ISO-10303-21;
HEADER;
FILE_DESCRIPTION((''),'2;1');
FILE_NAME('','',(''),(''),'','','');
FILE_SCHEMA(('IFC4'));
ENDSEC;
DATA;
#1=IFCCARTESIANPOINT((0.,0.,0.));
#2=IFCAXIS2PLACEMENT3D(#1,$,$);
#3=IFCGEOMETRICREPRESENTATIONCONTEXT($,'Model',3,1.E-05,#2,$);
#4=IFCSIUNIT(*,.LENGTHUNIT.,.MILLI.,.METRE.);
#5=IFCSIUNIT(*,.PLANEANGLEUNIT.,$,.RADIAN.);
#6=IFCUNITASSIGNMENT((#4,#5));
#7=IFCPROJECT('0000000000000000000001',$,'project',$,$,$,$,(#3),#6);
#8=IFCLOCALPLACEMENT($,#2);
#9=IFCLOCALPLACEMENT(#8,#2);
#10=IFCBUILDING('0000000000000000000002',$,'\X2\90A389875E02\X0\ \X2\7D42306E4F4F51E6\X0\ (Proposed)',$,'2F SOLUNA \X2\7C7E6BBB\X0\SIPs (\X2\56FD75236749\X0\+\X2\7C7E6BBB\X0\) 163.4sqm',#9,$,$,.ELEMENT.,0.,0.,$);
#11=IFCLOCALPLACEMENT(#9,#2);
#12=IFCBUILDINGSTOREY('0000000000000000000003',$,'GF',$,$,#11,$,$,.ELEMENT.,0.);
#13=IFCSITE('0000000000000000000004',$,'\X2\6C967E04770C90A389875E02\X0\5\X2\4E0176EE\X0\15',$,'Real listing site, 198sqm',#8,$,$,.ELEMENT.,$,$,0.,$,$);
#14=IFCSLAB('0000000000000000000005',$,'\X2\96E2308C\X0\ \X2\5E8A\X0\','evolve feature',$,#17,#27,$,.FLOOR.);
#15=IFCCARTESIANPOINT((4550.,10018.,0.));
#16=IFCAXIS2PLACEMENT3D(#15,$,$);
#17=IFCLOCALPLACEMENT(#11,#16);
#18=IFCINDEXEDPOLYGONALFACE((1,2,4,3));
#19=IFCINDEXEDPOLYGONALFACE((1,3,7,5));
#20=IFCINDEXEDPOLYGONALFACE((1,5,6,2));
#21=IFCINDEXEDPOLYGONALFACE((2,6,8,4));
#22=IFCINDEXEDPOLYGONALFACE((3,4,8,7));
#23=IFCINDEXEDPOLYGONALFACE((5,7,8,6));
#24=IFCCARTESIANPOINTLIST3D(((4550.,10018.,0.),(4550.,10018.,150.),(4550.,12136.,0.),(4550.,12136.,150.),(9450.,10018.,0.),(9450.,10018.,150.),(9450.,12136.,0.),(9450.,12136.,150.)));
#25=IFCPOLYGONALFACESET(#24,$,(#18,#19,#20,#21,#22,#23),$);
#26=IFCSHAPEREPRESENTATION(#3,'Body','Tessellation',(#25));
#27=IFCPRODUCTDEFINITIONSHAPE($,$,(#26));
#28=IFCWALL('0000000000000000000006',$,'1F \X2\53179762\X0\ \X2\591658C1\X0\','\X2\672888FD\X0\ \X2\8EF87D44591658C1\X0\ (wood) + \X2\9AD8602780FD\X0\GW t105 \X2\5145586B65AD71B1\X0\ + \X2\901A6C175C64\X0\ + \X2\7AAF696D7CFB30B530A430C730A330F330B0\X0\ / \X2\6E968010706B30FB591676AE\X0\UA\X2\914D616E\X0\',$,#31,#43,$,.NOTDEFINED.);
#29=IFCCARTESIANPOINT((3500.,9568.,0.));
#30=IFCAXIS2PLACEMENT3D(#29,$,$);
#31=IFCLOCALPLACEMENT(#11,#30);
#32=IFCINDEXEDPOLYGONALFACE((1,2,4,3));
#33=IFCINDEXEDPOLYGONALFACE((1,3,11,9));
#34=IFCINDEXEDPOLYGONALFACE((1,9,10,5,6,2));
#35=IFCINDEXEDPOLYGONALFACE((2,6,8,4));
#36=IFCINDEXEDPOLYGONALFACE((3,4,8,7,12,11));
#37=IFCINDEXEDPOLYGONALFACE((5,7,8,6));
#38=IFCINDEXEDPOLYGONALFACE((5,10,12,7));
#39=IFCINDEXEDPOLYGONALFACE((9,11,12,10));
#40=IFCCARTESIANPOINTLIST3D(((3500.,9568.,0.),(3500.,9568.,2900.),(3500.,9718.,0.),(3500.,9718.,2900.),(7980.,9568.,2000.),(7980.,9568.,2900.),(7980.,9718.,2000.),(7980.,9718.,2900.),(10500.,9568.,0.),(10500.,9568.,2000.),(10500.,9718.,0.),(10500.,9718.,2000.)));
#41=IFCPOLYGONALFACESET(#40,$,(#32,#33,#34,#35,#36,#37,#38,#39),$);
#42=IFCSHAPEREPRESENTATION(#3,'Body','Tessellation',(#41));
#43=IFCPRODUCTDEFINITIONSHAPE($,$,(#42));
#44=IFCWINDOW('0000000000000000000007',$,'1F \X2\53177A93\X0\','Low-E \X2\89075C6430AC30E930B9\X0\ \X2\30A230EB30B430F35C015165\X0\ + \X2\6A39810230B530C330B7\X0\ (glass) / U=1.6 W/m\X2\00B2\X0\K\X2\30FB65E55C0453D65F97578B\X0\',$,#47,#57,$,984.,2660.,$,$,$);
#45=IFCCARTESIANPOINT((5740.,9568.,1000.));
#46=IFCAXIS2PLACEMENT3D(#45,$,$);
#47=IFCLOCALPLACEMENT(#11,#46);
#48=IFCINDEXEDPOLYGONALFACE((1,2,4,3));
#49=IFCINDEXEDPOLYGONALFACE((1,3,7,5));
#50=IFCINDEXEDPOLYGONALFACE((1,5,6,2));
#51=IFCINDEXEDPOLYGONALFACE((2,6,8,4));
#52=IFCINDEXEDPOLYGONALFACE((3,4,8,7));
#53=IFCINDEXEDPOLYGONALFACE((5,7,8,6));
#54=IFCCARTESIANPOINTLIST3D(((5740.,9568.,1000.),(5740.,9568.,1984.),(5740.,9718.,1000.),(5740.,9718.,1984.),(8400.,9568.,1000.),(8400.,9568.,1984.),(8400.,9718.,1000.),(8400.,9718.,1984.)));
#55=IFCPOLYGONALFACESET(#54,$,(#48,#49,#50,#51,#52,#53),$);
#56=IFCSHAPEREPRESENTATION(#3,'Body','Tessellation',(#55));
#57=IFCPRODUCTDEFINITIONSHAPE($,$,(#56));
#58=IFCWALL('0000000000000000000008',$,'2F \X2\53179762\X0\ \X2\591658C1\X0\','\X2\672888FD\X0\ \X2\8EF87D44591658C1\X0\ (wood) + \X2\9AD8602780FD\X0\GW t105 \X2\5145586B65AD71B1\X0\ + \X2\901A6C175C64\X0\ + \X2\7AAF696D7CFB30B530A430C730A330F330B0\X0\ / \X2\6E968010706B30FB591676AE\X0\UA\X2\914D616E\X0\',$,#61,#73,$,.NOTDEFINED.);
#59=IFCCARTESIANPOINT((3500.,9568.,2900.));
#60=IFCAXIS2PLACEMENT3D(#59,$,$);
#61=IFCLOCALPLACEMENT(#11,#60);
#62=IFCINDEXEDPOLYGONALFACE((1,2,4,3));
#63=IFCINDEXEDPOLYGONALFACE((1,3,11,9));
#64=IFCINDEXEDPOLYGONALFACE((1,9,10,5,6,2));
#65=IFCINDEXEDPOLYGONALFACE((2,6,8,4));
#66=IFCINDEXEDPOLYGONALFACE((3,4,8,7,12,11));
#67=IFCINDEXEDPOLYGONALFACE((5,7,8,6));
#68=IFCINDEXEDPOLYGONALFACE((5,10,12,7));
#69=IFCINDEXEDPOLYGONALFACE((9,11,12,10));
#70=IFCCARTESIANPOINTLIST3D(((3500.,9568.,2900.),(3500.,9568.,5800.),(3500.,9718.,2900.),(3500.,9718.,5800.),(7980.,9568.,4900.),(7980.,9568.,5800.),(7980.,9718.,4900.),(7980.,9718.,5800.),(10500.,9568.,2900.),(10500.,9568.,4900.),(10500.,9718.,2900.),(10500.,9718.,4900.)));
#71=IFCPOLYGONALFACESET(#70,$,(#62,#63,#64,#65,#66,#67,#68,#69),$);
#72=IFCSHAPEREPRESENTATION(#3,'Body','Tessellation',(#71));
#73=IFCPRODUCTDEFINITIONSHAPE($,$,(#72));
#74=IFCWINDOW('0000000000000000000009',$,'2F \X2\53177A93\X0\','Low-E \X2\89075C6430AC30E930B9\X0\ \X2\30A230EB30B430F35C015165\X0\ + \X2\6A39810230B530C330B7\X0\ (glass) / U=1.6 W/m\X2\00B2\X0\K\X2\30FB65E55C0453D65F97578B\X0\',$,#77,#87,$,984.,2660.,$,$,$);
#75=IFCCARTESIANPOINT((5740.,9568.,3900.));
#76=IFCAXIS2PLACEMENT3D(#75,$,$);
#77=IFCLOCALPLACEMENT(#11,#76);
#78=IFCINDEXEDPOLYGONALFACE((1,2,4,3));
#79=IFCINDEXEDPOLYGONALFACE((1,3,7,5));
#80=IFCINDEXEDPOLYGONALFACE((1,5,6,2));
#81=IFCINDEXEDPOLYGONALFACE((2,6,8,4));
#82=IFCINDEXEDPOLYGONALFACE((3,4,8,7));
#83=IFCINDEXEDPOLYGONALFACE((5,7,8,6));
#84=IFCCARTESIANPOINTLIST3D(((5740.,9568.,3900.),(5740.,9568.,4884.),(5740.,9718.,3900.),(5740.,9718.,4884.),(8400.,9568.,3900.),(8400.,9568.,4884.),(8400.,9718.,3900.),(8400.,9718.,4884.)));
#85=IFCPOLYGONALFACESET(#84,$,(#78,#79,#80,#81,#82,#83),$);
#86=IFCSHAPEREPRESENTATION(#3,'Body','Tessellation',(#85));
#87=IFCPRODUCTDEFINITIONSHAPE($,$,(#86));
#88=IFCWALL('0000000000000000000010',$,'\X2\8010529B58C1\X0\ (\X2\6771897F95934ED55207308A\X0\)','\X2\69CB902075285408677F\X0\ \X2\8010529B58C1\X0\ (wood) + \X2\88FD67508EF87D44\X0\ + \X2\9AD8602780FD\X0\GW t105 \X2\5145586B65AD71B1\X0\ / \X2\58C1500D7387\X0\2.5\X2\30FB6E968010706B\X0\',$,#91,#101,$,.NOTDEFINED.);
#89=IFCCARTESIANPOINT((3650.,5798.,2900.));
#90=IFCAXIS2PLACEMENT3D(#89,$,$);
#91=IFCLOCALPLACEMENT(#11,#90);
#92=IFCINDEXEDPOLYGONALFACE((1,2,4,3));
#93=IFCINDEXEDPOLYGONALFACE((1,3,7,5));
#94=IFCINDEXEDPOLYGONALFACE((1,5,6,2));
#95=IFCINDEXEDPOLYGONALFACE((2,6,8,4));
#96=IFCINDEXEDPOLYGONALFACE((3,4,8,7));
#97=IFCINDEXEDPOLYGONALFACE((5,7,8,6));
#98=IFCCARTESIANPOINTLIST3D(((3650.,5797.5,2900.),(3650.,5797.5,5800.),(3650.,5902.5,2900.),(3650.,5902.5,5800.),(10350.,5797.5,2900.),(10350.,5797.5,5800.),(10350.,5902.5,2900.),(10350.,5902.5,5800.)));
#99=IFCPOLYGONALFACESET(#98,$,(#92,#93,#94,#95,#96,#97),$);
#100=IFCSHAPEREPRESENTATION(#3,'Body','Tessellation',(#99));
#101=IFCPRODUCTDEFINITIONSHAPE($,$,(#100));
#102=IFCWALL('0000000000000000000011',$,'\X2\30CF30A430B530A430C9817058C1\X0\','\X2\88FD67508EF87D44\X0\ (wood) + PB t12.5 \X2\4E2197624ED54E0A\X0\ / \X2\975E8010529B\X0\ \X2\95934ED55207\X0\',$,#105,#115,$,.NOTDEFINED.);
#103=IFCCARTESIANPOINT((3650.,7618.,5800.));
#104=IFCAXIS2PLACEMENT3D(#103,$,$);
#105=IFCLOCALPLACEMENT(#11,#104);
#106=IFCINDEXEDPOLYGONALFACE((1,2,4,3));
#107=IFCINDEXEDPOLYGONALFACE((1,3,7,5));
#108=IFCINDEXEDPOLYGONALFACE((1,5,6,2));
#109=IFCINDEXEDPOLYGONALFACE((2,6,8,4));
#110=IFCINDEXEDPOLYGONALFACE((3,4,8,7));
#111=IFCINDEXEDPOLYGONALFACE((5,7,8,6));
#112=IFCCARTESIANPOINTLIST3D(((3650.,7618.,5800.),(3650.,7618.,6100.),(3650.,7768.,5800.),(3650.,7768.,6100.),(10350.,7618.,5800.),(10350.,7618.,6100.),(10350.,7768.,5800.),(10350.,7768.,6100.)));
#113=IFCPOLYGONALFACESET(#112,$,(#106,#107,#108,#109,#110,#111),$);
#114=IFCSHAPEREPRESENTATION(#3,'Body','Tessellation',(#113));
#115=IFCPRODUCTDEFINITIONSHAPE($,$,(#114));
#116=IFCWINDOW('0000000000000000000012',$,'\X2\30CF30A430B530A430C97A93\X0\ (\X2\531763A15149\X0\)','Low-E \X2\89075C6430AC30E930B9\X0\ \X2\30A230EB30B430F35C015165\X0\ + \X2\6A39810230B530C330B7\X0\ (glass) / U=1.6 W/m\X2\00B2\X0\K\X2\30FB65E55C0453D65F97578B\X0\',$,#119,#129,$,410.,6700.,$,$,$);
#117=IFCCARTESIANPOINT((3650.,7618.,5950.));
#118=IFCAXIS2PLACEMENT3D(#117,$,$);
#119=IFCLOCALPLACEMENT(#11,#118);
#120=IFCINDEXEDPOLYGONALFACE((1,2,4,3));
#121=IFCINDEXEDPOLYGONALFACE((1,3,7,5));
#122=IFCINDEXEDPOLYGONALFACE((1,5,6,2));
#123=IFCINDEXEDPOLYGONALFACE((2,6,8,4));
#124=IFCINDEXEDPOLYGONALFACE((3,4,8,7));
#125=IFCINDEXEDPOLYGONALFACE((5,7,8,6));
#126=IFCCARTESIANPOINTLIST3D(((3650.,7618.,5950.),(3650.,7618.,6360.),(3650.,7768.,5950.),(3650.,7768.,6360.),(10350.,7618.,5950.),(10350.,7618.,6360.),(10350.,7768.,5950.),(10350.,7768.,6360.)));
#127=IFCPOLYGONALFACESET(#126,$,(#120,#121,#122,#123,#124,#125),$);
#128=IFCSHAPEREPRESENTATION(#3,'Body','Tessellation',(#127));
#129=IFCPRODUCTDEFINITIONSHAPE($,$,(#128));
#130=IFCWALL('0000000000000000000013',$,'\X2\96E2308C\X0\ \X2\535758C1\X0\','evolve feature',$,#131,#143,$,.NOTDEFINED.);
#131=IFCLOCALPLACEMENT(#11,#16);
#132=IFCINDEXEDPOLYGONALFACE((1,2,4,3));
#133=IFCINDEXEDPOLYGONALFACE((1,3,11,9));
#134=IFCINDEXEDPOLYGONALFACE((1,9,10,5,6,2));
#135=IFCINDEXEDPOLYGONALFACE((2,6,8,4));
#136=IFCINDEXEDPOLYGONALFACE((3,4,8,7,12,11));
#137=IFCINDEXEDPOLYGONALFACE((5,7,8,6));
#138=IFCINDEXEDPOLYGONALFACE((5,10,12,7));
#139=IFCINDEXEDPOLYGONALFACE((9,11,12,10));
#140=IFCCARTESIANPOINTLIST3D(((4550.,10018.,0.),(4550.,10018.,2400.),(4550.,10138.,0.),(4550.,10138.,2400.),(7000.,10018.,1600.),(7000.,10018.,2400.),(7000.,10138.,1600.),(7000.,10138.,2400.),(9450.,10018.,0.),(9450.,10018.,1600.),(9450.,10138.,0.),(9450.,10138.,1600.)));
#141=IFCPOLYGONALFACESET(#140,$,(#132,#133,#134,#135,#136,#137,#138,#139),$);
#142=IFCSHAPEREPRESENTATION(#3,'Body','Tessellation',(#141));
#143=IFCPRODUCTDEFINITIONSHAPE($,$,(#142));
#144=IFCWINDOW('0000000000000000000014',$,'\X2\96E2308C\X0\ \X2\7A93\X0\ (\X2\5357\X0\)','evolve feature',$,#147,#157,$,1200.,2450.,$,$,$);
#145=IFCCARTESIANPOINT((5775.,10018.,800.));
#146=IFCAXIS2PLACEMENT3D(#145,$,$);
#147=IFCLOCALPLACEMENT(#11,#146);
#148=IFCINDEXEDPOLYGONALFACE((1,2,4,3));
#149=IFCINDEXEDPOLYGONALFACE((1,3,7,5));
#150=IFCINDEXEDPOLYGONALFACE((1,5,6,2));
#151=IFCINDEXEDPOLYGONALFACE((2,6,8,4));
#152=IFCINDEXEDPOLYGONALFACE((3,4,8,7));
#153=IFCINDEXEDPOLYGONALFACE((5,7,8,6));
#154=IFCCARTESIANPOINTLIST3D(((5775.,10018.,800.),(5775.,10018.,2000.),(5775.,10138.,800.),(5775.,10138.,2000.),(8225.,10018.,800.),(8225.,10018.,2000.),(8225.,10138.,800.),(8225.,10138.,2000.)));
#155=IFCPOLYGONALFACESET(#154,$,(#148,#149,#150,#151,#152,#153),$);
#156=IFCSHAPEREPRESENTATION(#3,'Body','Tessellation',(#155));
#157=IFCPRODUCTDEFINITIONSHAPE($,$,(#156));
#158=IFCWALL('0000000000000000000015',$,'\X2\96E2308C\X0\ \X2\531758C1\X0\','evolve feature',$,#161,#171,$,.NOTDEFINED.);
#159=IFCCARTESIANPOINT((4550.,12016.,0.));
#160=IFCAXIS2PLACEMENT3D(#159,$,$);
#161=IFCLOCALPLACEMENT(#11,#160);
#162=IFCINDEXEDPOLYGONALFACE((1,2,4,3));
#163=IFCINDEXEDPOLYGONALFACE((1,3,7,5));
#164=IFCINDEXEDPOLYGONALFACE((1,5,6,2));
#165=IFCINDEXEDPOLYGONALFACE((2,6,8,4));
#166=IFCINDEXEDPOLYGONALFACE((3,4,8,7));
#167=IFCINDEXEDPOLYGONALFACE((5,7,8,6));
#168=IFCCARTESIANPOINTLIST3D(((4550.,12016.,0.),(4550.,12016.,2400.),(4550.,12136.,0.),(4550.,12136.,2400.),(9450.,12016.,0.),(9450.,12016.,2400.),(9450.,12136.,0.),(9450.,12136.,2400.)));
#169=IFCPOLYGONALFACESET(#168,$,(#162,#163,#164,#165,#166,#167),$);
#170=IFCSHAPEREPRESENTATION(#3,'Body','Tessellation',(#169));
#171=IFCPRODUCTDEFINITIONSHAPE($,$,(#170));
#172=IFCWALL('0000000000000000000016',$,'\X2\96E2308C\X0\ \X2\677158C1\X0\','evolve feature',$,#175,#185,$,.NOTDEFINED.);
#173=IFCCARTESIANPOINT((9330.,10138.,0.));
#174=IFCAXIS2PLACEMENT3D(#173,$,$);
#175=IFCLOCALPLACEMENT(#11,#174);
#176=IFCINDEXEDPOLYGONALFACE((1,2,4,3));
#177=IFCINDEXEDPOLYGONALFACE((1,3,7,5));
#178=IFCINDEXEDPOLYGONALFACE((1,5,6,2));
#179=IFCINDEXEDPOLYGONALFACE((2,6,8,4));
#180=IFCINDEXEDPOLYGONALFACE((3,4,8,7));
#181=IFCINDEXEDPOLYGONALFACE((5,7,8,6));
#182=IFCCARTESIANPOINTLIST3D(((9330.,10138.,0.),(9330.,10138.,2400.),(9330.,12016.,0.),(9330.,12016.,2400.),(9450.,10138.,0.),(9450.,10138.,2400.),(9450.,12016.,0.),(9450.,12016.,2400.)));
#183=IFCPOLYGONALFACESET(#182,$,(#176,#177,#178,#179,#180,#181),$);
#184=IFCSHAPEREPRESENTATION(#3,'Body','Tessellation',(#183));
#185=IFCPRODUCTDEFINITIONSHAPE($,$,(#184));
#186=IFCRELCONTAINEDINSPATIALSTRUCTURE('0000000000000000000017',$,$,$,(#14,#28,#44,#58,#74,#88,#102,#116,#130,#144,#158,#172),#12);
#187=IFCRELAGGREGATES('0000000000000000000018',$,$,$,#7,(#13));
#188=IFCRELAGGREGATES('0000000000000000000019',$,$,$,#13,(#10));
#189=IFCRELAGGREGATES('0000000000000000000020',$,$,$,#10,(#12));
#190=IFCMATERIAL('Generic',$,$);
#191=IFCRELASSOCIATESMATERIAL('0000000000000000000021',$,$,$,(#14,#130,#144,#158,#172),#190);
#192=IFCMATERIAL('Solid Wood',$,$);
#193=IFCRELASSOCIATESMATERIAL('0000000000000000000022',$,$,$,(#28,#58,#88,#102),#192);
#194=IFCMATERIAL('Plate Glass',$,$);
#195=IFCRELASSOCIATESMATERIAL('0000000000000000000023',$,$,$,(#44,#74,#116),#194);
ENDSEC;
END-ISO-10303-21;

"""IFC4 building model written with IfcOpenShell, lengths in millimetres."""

from ifc_helpers import new_model, si_unit, frame, frame_2d, origin, place, context, project, spatial, rectangle, extrude, material, element, fill, save


model = new_model("IFC4")

# Units and contexts
model_context = context("Model", 3, precision=1e-05, world=origin())
ifc_project = project(units=[si_unit("LENGTHUNIT", "METRE", prefix="MILLI"), si_unit("PLANEANGLEUNIT", "RADIAN")], contexts=[model_context])

# Site, building, storey
site_placement = place(None, origin())
site = spatial("IfcSite", under=ifc_project, at=site_placement, Name="沖縄県那覇市5丁目15", ObjectType="Real listing site, 198sqm", CompositionType="ELEMENT", RefElevation=0.0)
building_placement = place(site_placement, origin())
building = spatial("IfcBuilding", under=site, at=building_placement, Name="那覇市 終の住処 (Proposed)", ObjectType="2F SOLUNA 籾殻SIPs (国産杉+籾殻) 163.4sqm", CompositionType="ELEMENT", ElevationOfRefHeight=0.0, ElevationOfTerrain=0.0)
storey_placement = place(building_placement, origin())
storey = spatial("IfcBuildingStorey", under=building, at=storey_placement, Name="GF", CompositionType="ELEMENT", Elevation=0.0)

# Slab
ifc_material_1 = material(Name="Generic")
slab_placement = place(storey_placement, frame((4550.0, 10018.0, 0.0)))
element("IfcSlab", 1, at=slab_placement, inside=storey, material=ifc_material_1, Name="離れ 床", Description="evolve feature", PredefinedType="FLOOR", context=model_context, shape_type="SweptSolid", body=[
    extrude(rectangle(XDim=4900.0, YDim=2118.0, at=frame_2d((2450.0, 1059.0))), frame((4550.0, 10018.0, 0.0)), (0.0, 0.0, 1.0), 150.0),
])

# Wall, opening, window
ifc_material_2 = material(Name="Solid Wood")
wall_1_placement = place(storey_placement, frame((3500.0, 9568.0, 0.0)))
wall_1 = element("IfcWall", 2, at=wall_1_placement, inside=storey, material=ifc_material_2, Name="1F 北面 外壁", Description="木製 軸組外壁 (wood) + 高性能GW t105 充填断熱 + 通気層 + 窯業系サイディング / 準耐火・外皮UA配慮", PredefinedType="NOTDEFINED", context=model_context, shape_type="SweptSolid", body=[
    extrude(rectangle(XDim=7000.0, YDim=150.0, at=frame_2d((3500.0, 75.0))), frame((3500.0, 9568.0, 0.0)), (0.0, 0.0, 1.0), 2900.0),
])
opening_1_placement = place(storey_placement, frame((5740.0, 9568.0, 1000.0)))
opening_1 = element("IfcOpeningElement", 3, at=opening_1_placement, cuts=wall_1, PredefinedType="NOTDEFINED", context=model_context, shape_type="SweptSolid", body=[
    extrude(rectangle(XDim=2660.0, YDim=150.0, at=frame_2d((1330.0, 75.0))), frame((5740.0, 9568.0, 1000.0)), (0.0, 0.0, 1.0), 984.0),
])
ifc_material_3 = material(Name="Plate Glass")
window_1_placement = place(storey_placement, frame((5740.0, 9568.0, 1000.0)))
window_1 = element("IfcWindow", 4, at=window_1_placement, inside=storey, material=ifc_material_3, Name="1F 北窓", Description="Low-E 複層ガラス アルゴン封入 + 樹脂サッシ (glass) / U=1.6 W/m²K・日射取得型", OverallHeight=984.0, OverallWidth=2660.0, context=model_context, shape_type="SweptSolid", body=[
    extrude(rectangle(XDim=2660.0, YDim=150.0, at=frame_2d((1330.0, 75.0))), frame((5740.0, 9568.0, 1000.0)), (0.0, 0.0, 1.0), 984.0),
])
fill(opening_1, window_1)

# Wall, opening, window
wall_2_placement = place(storey_placement, frame((3500.0, 9568.0, 2900.0)))
wall_2 = element("IfcWall", 5, at=wall_2_placement, inside=storey, material=ifc_material_2, Name="2F 北面 外壁", Description="木製 軸組外壁 (wood) + 高性能GW t105 充填断熱 + 通気層 + 窯業系サイディング / 準耐火・外皮UA配慮", PredefinedType="NOTDEFINED", context=model_context, shape_type="SweptSolid", body=[
    extrude(rectangle(XDim=7000.0, YDim=150.0, at=frame_2d((3500.0, 75.0))), frame((3500.0, 9568.0, 2900.0)), (0.0, 0.0, 1.0), 2900.0),
])
opening_2_placement = place(storey_placement, frame((5740.0, 9568.0, 3900.0)))
opening_2 = element("IfcOpeningElement", 6, at=opening_2_placement, cuts=wall_2, PredefinedType="NOTDEFINED", context=model_context, shape_type="SweptSolid", body=[
    extrude(rectangle(XDim=2660.0, YDim=150.0, at=frame_2d((1330.0, 75.0))), frame((5740.0, 9568.0, 3900.0)), (0.0, 0.0, 1.0), 984.0),
])
window_2_placement = place(storey_placement, frame((5740.0, 9568.0, 3900.0)))
window_2 = element("IfcWindow", 7, at=window_2_placement, inside=storey, material=ifc_material_3, Name="2F 北窓", Description="Low-E 複層ガラス アルゴン封入 + 樹脂サッシ (glass) / U=1.6 W/m²K・日射取得型", OverallHeight=984.0, OverallWidth=2660.0, context=model_context, shape_type="SweptSolid", body=[
    extrude(rectangle(XDim=2660.0, YDim=150.0, at=frame_2d((1330.0, 75.0))), frame((5740.0, 9568.0, 3900.0)), (0.0, 0.0, 1.0), 984.0),
])
fill(opening_2, window_2)

# Wall
wall_3_placement = place(storey_placement, frame((3650.0, 5798.0, 2900.0)))
element("IfcWall", 8, at=wall_3_placement, inside=storey, material=ifc_material_2, Name="耐力壁 (東西間仕切り)", Description="構造用合板 耐力壁 (wood) + 製材軸組 + 高性能GW t105 充填断熱 / 壁倍率2.5・準耐火", PredefinedType="NOTDEFINED", context=model_context, shape_type="SweptSolid", body=[
    extrude(rectangle(XDim=6700.0, YDim=105.0, at=frame_2d((3350.0, 52.0))), frame((3650.0, 5798.0, 2900.0)), (0.0, 0.0, 1.0), 2900.0),
])

# Walls, openings, windows
wall_4_placement = place(storey_placement, frame((3650.0, 7618.0, 5800.0)))
wall_4 = element("IfcWall", 9, at=wall_4_placement, inside=storey, material=ifc_material_2, Name="ハイサイド腰壁", Description="製材軸組 (wood) + PB t12.5 両面仕上 / 非耐力 間仕切", PredefinedType="NOTDEFINED", context=model_context, shape_type="SweptSolid", body=[
    extrude(rectangle(XDim=6700.0, YDim=150.0, at=frame_2d((3350.0, 75.0))), frame((3650.0, 7618.0, 5800.0)), (0.0, 0.0, 1.0), 700.0),
])
opening_3_placement = place(storey_placement, frame((3650.0, 7618.0, 5950.0)))
opening_3 = element("IfcOpeningElement", 10, at=opening_3_placement, cuts=wall_4, PredefinedType="NOTDEFINED", context=model_context, shape_type="SweptSolid", body=[
    extrude(rectangle(XDim=6700.0, YDim=150.0, at=frame_2d((3350.0, 75.0))), frame((3650.0, 7618.0, 5950.0)), (0.0, 0.0, 1.0), 410.0),
])
window_3_placement = place(storey_placement, frame((3650.0, 7618.0, 5950.0)))
window_3 = element("IfcWindow", 11, at=window_3_placement, inside=storey, material=ifc_material_3, Name="ハイサイド窓 (北採光)", Description="Low-E 複層ガラス アルゴン封入 + 樹脂サッシ (glass) / U=1.6 W/m²K・日射取得型", OverallHeight=410.0, OverallWidth=6700.0, context=model_context, shape_type="SweptSolid", body=[
    extrude(rectangle(XDim=6700.0, YDim=150.0, at=frame_2d((3350.0, 75.0))), frame((3650.0, 7618.0, 5950.0)), (0.0, 0.0, 1.0), 410.0),
])
fill(opening_3, window_3)
wall_5_placement = place(storey_placement, frame((4550.0, 10018.0, 0.0)))
wall_5 = element("IfcWall", 12, at=wall_5_placement, inside=storey, material=ifc_material_1, Name="離れ 南壁", Description="evolve feature", PredefinedType="NOTDEFINED", context=model_context, shape_type="SweptSolid", body=[
    extrude(rectangle(XDim=4900.0, YDim=120.0, at=frame_2d((2450.0, 60.0))), frame((4550.0, 10018.0, 0.0)), (0.0, 0.0, 1.0), 2400.0),
])
opening_4_placement = place(storey_placement, frame((5775.0, 10018.0, 800.0)))
opening_4 = element("IfcOpeningElement", 13, at=opening_4_placement, cuts=wall_5, PredefinedType="NOTDEFINED", context=model_context, shape_type="SweptSolid", body=[
    extrude(rectangle(XDim=2450.0, YDim=120.0, at=frame_2d((1225.0, 60.0))), frame((5775.0, 10018.0, 800.0)), (0.0, 0.0, 1.0), 1200.0),
])
window_4_placement = place(storey_placement, frame((5775.0, 10018.0, 800.0)))
window_4 = element("IfcWindow", 14, at=window_4_placement, inside=storey, material=ifc_material_1, Name="離れ 窓 (南)", Description="evolve feature", OverallHeight=1200.0, OverallWidth=2450.0, context=model_context, shape_type="SweptSolid", body=[
    extrude(rectangle(XDim=2450.0, YDim=120.0, at=frame_2d((1225.0, 60.0))), frame((5775.0, 10018.0, 800.0)), (0.0, 0.0, 1.0), 1200.0),
])
fill(opening_4, window_4)

# Walls
wall_6_placement = place(storey_placement, frame((4550.0, 12016.0, 0.0)))
element("IfcWall", 15, at=wall_6_placement, inside=storey, material=ifc_material_1, Name="離れ 北壁", Description="evolve feature", PredefinedType="NOTDEFINED", context=model_context, shape_type="SweptSolid", body=[
    extrude(rectangle(XDim=4900.0, YDim=120.0, at=frame_2d((2450.0, 60.0))), frame((4550.0, 12016.0, 0.0)), (0.0, 0.0, 1.0), 2400.0),
])
wall_7_placement = place(storey_placement, frame((9330.0, 10138.0, 0.0)))
element("IfcWall", 16, at=wall_7_placement, inside=storey, material=ifc_material_1, Name="離れ 東壁", Description="evolve feature", PredefinedType="NOTDEFINED", context=model_context, shape_type="SweptSolid", body=[
    extrude(rectangle(XDim=120.0, YDim=1878.0, at=frame_2d((60.0, 939.0))), frame((9330.0, 10138.0, 0.0)), (0.0, 0.0, 1.0), 2400.0),
])

save(model, "model.ifc")
